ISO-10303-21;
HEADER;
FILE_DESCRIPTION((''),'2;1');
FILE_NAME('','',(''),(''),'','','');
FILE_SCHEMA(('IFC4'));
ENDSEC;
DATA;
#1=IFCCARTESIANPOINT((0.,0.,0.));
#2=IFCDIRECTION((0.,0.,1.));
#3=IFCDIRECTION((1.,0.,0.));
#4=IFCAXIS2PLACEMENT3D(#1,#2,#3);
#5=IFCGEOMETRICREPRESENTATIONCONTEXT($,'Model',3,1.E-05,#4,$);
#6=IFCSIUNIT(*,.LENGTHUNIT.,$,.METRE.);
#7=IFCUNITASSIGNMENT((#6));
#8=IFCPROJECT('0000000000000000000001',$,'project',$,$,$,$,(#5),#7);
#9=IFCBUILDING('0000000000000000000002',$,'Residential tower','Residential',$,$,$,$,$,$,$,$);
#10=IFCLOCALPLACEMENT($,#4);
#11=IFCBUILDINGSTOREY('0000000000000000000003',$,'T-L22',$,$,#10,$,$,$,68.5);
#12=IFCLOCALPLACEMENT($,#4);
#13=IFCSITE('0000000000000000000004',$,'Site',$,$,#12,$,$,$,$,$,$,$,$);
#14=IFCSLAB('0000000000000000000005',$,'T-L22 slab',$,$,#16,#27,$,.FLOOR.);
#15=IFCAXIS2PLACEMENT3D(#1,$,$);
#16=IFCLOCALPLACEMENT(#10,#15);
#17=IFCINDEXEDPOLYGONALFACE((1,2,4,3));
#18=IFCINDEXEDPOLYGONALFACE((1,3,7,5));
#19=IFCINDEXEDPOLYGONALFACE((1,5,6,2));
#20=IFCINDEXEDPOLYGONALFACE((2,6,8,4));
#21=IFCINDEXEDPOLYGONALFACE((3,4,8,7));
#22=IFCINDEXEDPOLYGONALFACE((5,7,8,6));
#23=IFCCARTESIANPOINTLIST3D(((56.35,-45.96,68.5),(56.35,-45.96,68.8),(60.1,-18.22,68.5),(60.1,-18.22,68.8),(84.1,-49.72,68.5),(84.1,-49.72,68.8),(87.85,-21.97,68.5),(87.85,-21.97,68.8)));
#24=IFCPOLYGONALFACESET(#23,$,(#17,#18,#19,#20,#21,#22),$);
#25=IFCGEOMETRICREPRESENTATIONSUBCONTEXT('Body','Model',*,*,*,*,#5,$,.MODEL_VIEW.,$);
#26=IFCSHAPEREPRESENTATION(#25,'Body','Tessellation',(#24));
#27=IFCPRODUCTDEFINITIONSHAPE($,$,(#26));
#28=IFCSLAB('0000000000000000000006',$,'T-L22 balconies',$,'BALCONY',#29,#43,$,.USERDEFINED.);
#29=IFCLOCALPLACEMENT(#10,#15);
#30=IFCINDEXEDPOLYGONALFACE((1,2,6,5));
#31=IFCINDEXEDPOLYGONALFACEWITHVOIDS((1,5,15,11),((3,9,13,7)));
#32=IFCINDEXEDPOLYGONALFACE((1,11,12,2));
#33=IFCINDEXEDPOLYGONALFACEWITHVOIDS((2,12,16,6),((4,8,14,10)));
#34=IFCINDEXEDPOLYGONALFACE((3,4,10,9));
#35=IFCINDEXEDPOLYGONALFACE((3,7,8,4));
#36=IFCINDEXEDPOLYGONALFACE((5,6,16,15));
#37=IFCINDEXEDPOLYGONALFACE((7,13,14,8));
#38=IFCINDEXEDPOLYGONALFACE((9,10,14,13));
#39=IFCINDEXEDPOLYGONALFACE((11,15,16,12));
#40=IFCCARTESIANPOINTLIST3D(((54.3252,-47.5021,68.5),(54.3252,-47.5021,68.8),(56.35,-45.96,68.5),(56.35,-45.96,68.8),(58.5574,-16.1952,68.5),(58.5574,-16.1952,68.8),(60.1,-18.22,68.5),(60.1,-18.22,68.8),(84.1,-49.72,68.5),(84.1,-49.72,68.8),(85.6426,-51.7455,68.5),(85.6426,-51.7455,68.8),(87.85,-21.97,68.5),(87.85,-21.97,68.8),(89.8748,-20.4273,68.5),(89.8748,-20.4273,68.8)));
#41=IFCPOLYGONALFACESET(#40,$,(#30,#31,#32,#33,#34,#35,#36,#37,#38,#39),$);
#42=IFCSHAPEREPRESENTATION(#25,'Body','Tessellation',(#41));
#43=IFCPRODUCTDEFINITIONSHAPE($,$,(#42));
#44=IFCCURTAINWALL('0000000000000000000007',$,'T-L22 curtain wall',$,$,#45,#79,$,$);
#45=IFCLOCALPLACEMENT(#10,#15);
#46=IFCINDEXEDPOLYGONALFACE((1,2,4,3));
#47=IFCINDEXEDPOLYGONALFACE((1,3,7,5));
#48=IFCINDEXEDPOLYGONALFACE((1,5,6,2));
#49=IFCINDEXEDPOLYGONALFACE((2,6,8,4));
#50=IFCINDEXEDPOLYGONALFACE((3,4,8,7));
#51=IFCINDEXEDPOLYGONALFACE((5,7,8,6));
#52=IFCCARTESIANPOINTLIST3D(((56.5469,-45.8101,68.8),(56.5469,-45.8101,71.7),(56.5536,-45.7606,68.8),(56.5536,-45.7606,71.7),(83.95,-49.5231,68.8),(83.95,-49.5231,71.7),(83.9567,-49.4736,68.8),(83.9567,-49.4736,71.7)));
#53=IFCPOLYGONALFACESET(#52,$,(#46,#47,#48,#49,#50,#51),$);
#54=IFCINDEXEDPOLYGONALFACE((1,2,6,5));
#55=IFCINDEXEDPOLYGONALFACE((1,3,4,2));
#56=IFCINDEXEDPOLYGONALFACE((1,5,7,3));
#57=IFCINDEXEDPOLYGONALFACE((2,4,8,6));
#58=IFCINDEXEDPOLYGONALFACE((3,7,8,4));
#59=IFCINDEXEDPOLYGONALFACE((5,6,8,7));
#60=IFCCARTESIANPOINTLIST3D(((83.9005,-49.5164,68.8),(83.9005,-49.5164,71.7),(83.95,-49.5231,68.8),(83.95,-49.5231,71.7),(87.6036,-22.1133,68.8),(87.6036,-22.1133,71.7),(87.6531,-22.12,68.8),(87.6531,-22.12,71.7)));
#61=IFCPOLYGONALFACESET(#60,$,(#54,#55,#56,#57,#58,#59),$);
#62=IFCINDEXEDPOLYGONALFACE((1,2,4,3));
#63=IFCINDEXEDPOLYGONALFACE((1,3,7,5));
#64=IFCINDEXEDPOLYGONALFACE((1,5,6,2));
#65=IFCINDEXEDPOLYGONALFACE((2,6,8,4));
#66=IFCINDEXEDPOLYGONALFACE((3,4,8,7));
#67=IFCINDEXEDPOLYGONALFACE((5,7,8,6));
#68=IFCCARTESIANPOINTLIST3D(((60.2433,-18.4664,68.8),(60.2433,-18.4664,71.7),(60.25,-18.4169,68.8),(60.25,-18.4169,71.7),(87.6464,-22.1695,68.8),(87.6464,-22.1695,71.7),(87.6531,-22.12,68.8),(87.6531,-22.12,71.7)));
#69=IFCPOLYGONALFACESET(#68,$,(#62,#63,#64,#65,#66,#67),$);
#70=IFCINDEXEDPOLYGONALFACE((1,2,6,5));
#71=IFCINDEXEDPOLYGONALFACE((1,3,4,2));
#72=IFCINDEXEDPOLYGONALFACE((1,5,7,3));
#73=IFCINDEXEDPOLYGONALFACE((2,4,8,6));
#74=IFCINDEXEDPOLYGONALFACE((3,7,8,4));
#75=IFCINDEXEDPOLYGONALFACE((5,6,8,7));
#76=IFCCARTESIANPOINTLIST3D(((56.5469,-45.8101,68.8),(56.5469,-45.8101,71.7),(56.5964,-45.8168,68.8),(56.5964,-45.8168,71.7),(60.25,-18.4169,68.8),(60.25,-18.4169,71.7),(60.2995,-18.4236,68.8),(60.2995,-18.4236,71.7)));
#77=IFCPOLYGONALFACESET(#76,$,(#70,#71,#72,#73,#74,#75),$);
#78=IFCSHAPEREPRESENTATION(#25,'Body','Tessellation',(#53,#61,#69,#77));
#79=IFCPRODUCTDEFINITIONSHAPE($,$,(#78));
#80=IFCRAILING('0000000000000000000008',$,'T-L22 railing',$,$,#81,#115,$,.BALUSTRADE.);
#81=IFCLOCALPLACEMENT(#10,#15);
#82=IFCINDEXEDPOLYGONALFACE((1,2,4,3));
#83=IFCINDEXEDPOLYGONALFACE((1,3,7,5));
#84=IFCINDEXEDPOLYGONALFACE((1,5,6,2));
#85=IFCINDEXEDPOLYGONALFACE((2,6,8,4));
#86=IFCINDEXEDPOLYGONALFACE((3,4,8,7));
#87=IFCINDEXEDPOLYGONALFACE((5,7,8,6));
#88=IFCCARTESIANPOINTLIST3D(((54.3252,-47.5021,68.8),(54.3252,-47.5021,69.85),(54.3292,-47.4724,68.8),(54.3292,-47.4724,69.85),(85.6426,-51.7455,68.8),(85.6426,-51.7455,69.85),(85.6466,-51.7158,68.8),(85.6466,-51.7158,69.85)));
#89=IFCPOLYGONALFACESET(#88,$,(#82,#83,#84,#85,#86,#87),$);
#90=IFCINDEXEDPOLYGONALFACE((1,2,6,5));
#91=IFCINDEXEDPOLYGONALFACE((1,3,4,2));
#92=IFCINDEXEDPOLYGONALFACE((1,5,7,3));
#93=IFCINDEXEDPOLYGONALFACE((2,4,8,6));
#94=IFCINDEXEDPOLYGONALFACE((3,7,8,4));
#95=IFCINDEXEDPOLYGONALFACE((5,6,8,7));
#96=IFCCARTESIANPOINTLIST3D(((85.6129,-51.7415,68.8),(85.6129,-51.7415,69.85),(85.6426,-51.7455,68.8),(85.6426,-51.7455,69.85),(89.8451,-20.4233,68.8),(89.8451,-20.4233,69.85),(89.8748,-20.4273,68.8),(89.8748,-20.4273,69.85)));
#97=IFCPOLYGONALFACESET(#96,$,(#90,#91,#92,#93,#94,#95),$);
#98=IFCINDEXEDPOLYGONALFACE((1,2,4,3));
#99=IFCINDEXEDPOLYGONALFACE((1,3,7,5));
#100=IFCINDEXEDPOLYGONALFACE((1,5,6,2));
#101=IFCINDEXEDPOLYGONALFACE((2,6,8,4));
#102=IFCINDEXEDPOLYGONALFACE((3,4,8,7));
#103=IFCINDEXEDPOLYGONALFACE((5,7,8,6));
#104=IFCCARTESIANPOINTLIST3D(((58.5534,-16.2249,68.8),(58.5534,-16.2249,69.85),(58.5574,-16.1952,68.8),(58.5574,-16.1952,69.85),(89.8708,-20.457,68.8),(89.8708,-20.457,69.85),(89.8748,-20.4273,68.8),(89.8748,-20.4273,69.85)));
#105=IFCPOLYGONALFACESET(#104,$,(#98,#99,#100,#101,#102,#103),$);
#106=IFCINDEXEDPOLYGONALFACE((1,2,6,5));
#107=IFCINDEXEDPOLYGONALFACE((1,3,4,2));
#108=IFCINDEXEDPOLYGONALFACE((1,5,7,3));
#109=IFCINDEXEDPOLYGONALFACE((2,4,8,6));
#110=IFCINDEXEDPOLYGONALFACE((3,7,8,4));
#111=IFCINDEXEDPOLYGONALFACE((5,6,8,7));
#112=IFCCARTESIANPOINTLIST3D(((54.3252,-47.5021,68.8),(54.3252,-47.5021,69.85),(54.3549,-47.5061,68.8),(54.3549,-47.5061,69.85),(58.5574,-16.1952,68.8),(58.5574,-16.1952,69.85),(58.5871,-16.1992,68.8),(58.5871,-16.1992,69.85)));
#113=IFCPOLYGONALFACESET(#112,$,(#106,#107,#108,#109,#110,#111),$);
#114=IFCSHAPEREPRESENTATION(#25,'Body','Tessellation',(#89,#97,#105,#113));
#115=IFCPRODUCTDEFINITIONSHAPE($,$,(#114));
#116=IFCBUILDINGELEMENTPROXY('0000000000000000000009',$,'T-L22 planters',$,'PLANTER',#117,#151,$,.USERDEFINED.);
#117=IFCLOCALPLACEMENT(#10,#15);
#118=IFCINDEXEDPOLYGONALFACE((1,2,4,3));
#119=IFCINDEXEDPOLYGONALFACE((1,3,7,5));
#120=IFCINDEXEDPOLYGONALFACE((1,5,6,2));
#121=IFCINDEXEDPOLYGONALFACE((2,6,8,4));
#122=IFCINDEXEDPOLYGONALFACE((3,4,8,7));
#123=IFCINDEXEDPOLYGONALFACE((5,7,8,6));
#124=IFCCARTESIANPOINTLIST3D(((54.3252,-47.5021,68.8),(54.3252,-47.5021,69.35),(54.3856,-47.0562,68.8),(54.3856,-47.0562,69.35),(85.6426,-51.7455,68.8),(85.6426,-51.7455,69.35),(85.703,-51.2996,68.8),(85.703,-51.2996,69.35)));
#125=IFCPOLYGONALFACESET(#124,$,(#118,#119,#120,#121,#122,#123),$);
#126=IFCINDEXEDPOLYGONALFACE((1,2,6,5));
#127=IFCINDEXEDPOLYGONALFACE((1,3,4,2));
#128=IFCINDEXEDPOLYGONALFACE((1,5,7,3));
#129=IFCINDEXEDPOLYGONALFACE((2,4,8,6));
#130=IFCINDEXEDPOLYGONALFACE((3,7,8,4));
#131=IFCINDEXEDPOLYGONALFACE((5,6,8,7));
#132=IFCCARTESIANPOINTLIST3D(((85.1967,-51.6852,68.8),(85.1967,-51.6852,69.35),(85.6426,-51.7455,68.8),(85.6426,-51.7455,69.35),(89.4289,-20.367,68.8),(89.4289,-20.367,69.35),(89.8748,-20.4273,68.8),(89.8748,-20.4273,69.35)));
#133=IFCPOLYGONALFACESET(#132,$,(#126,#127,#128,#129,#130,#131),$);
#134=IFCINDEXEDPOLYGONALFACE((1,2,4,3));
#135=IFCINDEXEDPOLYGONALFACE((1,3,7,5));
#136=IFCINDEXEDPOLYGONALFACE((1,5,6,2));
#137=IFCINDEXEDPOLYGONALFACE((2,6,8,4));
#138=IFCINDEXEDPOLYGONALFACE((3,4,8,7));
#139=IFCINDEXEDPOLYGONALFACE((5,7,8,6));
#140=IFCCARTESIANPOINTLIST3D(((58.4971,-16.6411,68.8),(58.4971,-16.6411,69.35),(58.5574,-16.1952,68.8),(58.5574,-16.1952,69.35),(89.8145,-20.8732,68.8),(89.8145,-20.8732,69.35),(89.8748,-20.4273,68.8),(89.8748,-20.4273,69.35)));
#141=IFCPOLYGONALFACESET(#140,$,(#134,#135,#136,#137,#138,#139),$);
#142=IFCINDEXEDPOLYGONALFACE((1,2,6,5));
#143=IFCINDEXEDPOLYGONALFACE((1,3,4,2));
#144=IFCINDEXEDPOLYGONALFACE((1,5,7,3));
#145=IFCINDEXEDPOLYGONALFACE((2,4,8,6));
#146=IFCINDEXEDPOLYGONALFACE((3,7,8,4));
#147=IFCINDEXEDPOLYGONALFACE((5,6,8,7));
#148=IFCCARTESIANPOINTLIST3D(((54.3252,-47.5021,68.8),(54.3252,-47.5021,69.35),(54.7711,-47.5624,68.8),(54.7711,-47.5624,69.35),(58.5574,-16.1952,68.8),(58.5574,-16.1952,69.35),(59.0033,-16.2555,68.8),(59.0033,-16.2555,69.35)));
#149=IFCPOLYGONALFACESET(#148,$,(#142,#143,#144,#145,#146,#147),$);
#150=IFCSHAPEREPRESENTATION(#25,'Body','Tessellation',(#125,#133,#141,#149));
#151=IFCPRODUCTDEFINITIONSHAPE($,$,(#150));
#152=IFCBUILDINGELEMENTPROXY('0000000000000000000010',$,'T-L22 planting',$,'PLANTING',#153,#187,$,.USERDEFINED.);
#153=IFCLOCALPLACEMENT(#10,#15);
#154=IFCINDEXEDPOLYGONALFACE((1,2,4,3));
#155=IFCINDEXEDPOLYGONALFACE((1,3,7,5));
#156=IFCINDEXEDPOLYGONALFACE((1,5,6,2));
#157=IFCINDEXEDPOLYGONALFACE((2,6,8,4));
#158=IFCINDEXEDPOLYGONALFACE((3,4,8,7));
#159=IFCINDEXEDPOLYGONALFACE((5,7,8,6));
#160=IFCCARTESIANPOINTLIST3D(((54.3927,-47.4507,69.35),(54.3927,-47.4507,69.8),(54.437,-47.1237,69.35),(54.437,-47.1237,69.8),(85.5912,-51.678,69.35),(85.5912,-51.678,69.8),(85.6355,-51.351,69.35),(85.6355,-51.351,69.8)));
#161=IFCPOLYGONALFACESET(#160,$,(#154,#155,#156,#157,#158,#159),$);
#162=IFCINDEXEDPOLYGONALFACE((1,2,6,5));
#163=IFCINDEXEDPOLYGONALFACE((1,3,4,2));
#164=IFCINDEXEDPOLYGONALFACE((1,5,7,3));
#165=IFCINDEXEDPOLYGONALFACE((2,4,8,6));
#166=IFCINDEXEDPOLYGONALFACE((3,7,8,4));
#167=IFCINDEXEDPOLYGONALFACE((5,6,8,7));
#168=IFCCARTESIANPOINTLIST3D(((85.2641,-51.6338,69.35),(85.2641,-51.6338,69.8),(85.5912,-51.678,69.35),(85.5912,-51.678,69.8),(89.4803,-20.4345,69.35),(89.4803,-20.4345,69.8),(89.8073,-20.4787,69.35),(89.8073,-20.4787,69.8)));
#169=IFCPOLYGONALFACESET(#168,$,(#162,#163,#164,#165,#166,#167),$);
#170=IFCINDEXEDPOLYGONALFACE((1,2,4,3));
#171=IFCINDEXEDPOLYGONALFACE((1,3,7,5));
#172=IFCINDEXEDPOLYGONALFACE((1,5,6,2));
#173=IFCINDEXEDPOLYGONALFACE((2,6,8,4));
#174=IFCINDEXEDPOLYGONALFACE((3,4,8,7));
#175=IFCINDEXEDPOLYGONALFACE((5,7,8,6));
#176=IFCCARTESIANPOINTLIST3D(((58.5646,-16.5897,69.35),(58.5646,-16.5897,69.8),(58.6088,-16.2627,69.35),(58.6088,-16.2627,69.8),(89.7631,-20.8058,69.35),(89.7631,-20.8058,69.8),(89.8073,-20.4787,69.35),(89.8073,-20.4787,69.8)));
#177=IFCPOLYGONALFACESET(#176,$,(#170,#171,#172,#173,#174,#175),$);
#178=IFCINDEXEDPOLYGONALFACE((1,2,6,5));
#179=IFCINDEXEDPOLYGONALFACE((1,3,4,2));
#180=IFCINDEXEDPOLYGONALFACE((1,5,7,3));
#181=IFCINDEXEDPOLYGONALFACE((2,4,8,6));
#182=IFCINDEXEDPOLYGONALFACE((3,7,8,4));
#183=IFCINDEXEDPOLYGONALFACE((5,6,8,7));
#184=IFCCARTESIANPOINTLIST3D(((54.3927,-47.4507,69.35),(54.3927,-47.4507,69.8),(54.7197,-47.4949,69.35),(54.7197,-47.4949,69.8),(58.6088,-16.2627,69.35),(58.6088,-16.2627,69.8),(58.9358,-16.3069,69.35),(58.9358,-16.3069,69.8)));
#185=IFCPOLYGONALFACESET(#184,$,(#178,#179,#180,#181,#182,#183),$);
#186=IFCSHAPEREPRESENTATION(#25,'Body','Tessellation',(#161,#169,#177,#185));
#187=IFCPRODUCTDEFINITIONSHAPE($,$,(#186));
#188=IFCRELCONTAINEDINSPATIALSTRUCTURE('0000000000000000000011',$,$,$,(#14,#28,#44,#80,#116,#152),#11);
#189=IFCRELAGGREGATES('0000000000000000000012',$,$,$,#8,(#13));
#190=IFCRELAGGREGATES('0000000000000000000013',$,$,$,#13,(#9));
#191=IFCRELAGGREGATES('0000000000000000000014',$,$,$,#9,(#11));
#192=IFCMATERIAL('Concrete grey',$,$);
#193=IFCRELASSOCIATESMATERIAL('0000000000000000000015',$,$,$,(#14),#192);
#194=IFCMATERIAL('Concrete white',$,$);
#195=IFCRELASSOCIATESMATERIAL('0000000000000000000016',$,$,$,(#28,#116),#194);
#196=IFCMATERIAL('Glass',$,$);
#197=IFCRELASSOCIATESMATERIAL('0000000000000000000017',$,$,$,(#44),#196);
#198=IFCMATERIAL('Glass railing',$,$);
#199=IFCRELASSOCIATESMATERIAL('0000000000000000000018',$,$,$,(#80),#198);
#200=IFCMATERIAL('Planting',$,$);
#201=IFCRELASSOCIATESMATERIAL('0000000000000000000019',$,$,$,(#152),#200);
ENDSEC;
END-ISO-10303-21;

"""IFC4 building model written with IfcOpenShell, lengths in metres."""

from ifc_helpers import new_model, si_unit, frame, origin_with_axes, place, context, subcontext, project, spatial, polyline, outline, extrude, material, element, save


model = new_model("IFC4")

# Units and contexts
model_context = context("Model", 3, precision=1e-05, world=origin_with_axes())
body_context = subcontext(model_context, "Body", "Model", "MODEL_VIEW")
ifc_project = project(units=[si_unit("LENGTHUNIT", "METRE")], contexts=[model_context])

# Site, building, storey
site_placement = place(None, origin_with_axes())
site = spatial("IfcSite", under=ifc_project, at=site_placement, Name="Site")
building = spatial("IfcBuilding", under=site, Name="Residential tower", Description="Residential")
storey_placement = place(None, origin_with_axes())
storey = spatial("IfcBuildingStorey", under=building, at=storey_placement, Name="T-L22", Elevation=68.5)

# Slabs
ifc_material_1 = material(Name="Concrete grey")
slab_1_placement = place(storey_placement, origin_with_axes())
element("IfcSlab", 1, at=slab_1_placement, inside=storey, material=ifc_material_1, Name="T-L22 slab", PredefinedType="FLOOR", context=body_context, shape_type="SweptSolid", body=[
    extrude(outline(polyline([(56.35, -45.96), (84.1, -49.72), (87.85, -21.97), (60.1, -18.22), (56.35, -45.96)])), frame((0.0, 0.0, 68.5), z_axis=(0.0, 0.0, 1.0), x_axis=(1.0, 0.0, 0.0)), (0.0, 0.0, 1.0), 0.3),
])
ifc_material_2 = material(Name="Concrete white")
slab_2_placement = place(storey_placement, origin_with_axes())
element("IfcSlab", 2, at=slab_2_placement, inside=storey, material=ifc_material_2, Name="T-L22 balconies", ObjectType="BALCONY", PredefinedType="USERDEFINED", context=body_context, shape_type="SweptSolid", body=[
    extrude(outline(polyline([(54.3252, -47.5021), (85.6426, -51.7455), (89.8748, -20.4273), (58.5574, -16.1952), (54.3252, -47.5021)]), holes=[polyline([(56.35, -45.96), (84.1, -49.72), (87.85, -21.97), (60.1, -18.22), (56.35, -45.96)])]), frame((0.0, 0.0, 68.5), z_axis=(0.0, 0.0, 1.0), x_axis=(1.0, 0.0, 0.0)), (0.0, 0.0, 1.0), 0.3),
])

# Curtain wall
ifc_material_3 = material(Name="Glass")
curtain_wall_placement = place(storey_placement, origin_with_axes())
element("IfcCurtainWall", 3, at=curtain_wall_placement, inside=storey, material=ifc_material_3, Name="T-L22 curtain wall", context=body_context, shape_type="SweptSolid", body=[
    extrude(outline(polyline([(56.5469, -45.8101), (83.95, -49.5231), (83.9567, -49.4736), (56.5536, -45.7606), (56.5469, -45.8101)])), frame((0.0, 0.0, 68.8), z_axis=(0.0, 0.0, 1.0), x_axis=(1.0, 0.0, 0.0)), (0.0, 0.0, 1.0), 2.9),
    extrude(outline(polyline([(83.95, -49.5231), (87.6531, -22.12), (87.6036, -22.1133), (83.9005, -49.5164), (83.95, -49.5231)])), frame((0.0, 0.0, 68.8), z_axis=(0.0, 0.0, 1.0), x_axis=(1.0, 0.0, 0.0)), (0.0, 0.0, 1.0), 2.9),
    extrude(outline(polyline([(87.6531, -22.12), (60.25, -18.4169), (60.2433, -18.4664), (87.6464, -22.1695), (87.6531, -22.12)])), frame((0.0, 0.0, 68.8), z_axis=(0.0, 0.0, 1.0), x_axis=(1.0, 0.0, 0.0)), (0.0, 0.0, 1.0), 2.9),
    extrude(outline(polyline([(60.25, -18.4169), (56.5469, -45.8101), (56.5964, -45.8168), (60.2995, -18.4236), (60.25, -18.4169)])), frame((0.0, 0.0, 68.8), z_axis=(0.0, 0.0, 1.0), x_axis=(1.0, 0.0, 0.0)), (0.0, 0.0, 1.0), 2.9),
])

# Railing
ifc_material_4 = material(Name="Glass railing")
railing_placement = place(storey_placement, origin_with_axes())
element("IfcRailing", 4, at=railing_placement, inside=storey, material=ifc_material_4, Name="T-L22 railing", PredefinedType="BALUSTRADE", context=body_context, shape_type="SweptSolid", body=[
    extrude(outline(polyline([(54.3252, -47.5021), (85.6426, -51.7455), (85.6466, -51.7158), (54.3292, -47.4724), (54.3252, -47.5021)])), frame((0.0, 0.0, 68.8), z_axis=(0.0, 0.0, 1.0), x_axis=(1.0, 0.0, 0.0)), (0.0, 0.0, 1.0), 1.05),
    extrude(outline(polyline([(85.6426, -51.7455), (89.8748, -20.4273), (89.8451, -20.4233), (85.6129, -51.7415), (85.6426, -51.7455)])), frame((0.0, 0.0, 68.8), z_axis=(0.0, 0.0, 1.0), x_axis=(1.0, 0.0, 0.0)), (0.0, 0.0, 1.0), 1.05),
    extrude(outline(polyline([(89.8748, -20.4273), (58.5574, -16.1952), (58.5534, -16.2249), (89.8708, -20.457), (89.8748, -20.4273)])), frame((0.0, 0.0, 68.8), z_axis=(0.0, 0.0, 1.0), x_axis=(1.0, 0.0, 0.0)), (0.0, 0.0, 1.0), 1.05),
    extrude(outline(polyline([(58.5574, -16.1952), (54.3252, -47.5021), (54.3549, -47.5061), (58.5871, -16.1992), (58.5574, -16.1952)])), frame((0.0, 0.0, 68.8), z_axis=(0.0, 0.0, 1.0), x_axis=(1.0, 0.0, 0.0)), (0.0, 0.0, 1.0), 1.05),
])

# Building element proxies
proxy_1_placement = place(storey_placement, origin_with_axes())
element("IfcBuildingElementProxy", 5, at=proxy_1_placement, inside=storey, material=ifc_material_2, Name="T-L22 planters", ObjectType="PLANTER", PredefinedType="USERDEFINED", context=body_context, shape_type="SweptSolid", body=[
    extrude(outline(polyline([(54.3252, -47.5021), (85.6426, -51.7455), (85.703, -51.2996), (54.3856, -47.0562), (54.3252, -47.5021)])), frame((0.0, 0.0, 68.8), z_axis=(0.0, 0.0, 1.0), x_axis=(1.0, 0.0, 0.0)), (0.0, 0.0, 1.0), 0.55),
    extrude(outline(polyline([(85.6426, -51.7455), (89.8748, -20.4273), (89.4289, -20.367), (85.1967, -51.6852), (85.6426, -51.7455)])), frame((0.0, 0.0, 68.8), z_axis=(0.0, 0.0, 1.0), x_axis=(1.0, 0.0, 0.0)), (0.0, 0.0, 1.0), 0.55),
    extrude(outline(polyline([(89.8748, -20.4273), (58.5574, -16.1952), (58.4971, -16.6411), (89.8145, -20.8732), (89.8748, -20.4273)])), frame((0.0, 0.0, 68.8), z_axis=(0.0, 0.0, 1.0), x_axis=(1.0, 0.0, 0.0)), (0.0, 0.0, 1.0), 0.55),
    extrude(outline(polyline([(58.5574, -16.1952), (54.3252, -47.5021), (54.7711, -47.5624), (59.0033, -16.2555), (58.5574, -16.1952)])), frame((0.0, 0.0, 68.8), z_axis=(0.0, 0.0, 1.0), x_axis=(1.0, 0.0, 0.0)), (0.0, 0.0, 1.0), 0.55),
])
ifc_material_5 = material(Name="Planting")
proxy_2_placement = place(storey_placement, origin_with_axes())
element("IfcBuildingElementProxy", 6, at=proxy_2_placement, inside=storey, material=ifc_material_5, Name="T-L22 planting", ObjectType="PLANTING", PredefinedType="USERDEFINED", context=body_context, shape_type="SweptSolid", body=[
    extrude(outline(polyline([(54.3927, -47.4507), (85.5912, -51.678), (85.6355, -51.351), (54.437, -47.1237), (54.3927, -47.4507)])), frame((0.0, 0.0, 69.35), z_axis=(0.0, 0.0, 1.0), x_axis=(1.0, 0.0, 0.0)), (0.0, 0.0, 1.0), 0.45),
    extrude(outline(polyline([(85.5912, -51.678), (89.8073, -20.4787), (89.4803, -20.4345), (85.2641, -51.6338), (85.5912, -51.678)])), frame((0.0, 0.0, 69.35), z_axis=(0.0, 0.0, 1.0), x_axis=(1.0, 0.0, 0.0)), (0.0, 0.0, 1.0), 0.45),
    extrude(outline(polyline([(89.8073, -20.4787), (58.6088, -16.2627), (58.5646, -16.5897), (89.7631, -20.8058), (89.8073, -20.4787)])), frame((0.0, 0.0, 69.35), z_axis=(0.0, 0.0, 1.0), x_axis=(1.0, 0.0, 0.0)), (0.0, 0.0, 1.0), 0.45),
    extrude(outline(polyline([(58.6088, -16.2627), (54.3927, -47.4507), (54.7197, -47.4949), (58.9358, -16.3069), (58.6088, -16.2627)])), frame((0.0, 0.0, 69.35), z_axis=(0.0, 0.0, 1.0), x_axis=(1.0, 0.0, 0.0)), (0.0, 0.0, 1.0), 0.45),
])

save(model, "model.ifc")
